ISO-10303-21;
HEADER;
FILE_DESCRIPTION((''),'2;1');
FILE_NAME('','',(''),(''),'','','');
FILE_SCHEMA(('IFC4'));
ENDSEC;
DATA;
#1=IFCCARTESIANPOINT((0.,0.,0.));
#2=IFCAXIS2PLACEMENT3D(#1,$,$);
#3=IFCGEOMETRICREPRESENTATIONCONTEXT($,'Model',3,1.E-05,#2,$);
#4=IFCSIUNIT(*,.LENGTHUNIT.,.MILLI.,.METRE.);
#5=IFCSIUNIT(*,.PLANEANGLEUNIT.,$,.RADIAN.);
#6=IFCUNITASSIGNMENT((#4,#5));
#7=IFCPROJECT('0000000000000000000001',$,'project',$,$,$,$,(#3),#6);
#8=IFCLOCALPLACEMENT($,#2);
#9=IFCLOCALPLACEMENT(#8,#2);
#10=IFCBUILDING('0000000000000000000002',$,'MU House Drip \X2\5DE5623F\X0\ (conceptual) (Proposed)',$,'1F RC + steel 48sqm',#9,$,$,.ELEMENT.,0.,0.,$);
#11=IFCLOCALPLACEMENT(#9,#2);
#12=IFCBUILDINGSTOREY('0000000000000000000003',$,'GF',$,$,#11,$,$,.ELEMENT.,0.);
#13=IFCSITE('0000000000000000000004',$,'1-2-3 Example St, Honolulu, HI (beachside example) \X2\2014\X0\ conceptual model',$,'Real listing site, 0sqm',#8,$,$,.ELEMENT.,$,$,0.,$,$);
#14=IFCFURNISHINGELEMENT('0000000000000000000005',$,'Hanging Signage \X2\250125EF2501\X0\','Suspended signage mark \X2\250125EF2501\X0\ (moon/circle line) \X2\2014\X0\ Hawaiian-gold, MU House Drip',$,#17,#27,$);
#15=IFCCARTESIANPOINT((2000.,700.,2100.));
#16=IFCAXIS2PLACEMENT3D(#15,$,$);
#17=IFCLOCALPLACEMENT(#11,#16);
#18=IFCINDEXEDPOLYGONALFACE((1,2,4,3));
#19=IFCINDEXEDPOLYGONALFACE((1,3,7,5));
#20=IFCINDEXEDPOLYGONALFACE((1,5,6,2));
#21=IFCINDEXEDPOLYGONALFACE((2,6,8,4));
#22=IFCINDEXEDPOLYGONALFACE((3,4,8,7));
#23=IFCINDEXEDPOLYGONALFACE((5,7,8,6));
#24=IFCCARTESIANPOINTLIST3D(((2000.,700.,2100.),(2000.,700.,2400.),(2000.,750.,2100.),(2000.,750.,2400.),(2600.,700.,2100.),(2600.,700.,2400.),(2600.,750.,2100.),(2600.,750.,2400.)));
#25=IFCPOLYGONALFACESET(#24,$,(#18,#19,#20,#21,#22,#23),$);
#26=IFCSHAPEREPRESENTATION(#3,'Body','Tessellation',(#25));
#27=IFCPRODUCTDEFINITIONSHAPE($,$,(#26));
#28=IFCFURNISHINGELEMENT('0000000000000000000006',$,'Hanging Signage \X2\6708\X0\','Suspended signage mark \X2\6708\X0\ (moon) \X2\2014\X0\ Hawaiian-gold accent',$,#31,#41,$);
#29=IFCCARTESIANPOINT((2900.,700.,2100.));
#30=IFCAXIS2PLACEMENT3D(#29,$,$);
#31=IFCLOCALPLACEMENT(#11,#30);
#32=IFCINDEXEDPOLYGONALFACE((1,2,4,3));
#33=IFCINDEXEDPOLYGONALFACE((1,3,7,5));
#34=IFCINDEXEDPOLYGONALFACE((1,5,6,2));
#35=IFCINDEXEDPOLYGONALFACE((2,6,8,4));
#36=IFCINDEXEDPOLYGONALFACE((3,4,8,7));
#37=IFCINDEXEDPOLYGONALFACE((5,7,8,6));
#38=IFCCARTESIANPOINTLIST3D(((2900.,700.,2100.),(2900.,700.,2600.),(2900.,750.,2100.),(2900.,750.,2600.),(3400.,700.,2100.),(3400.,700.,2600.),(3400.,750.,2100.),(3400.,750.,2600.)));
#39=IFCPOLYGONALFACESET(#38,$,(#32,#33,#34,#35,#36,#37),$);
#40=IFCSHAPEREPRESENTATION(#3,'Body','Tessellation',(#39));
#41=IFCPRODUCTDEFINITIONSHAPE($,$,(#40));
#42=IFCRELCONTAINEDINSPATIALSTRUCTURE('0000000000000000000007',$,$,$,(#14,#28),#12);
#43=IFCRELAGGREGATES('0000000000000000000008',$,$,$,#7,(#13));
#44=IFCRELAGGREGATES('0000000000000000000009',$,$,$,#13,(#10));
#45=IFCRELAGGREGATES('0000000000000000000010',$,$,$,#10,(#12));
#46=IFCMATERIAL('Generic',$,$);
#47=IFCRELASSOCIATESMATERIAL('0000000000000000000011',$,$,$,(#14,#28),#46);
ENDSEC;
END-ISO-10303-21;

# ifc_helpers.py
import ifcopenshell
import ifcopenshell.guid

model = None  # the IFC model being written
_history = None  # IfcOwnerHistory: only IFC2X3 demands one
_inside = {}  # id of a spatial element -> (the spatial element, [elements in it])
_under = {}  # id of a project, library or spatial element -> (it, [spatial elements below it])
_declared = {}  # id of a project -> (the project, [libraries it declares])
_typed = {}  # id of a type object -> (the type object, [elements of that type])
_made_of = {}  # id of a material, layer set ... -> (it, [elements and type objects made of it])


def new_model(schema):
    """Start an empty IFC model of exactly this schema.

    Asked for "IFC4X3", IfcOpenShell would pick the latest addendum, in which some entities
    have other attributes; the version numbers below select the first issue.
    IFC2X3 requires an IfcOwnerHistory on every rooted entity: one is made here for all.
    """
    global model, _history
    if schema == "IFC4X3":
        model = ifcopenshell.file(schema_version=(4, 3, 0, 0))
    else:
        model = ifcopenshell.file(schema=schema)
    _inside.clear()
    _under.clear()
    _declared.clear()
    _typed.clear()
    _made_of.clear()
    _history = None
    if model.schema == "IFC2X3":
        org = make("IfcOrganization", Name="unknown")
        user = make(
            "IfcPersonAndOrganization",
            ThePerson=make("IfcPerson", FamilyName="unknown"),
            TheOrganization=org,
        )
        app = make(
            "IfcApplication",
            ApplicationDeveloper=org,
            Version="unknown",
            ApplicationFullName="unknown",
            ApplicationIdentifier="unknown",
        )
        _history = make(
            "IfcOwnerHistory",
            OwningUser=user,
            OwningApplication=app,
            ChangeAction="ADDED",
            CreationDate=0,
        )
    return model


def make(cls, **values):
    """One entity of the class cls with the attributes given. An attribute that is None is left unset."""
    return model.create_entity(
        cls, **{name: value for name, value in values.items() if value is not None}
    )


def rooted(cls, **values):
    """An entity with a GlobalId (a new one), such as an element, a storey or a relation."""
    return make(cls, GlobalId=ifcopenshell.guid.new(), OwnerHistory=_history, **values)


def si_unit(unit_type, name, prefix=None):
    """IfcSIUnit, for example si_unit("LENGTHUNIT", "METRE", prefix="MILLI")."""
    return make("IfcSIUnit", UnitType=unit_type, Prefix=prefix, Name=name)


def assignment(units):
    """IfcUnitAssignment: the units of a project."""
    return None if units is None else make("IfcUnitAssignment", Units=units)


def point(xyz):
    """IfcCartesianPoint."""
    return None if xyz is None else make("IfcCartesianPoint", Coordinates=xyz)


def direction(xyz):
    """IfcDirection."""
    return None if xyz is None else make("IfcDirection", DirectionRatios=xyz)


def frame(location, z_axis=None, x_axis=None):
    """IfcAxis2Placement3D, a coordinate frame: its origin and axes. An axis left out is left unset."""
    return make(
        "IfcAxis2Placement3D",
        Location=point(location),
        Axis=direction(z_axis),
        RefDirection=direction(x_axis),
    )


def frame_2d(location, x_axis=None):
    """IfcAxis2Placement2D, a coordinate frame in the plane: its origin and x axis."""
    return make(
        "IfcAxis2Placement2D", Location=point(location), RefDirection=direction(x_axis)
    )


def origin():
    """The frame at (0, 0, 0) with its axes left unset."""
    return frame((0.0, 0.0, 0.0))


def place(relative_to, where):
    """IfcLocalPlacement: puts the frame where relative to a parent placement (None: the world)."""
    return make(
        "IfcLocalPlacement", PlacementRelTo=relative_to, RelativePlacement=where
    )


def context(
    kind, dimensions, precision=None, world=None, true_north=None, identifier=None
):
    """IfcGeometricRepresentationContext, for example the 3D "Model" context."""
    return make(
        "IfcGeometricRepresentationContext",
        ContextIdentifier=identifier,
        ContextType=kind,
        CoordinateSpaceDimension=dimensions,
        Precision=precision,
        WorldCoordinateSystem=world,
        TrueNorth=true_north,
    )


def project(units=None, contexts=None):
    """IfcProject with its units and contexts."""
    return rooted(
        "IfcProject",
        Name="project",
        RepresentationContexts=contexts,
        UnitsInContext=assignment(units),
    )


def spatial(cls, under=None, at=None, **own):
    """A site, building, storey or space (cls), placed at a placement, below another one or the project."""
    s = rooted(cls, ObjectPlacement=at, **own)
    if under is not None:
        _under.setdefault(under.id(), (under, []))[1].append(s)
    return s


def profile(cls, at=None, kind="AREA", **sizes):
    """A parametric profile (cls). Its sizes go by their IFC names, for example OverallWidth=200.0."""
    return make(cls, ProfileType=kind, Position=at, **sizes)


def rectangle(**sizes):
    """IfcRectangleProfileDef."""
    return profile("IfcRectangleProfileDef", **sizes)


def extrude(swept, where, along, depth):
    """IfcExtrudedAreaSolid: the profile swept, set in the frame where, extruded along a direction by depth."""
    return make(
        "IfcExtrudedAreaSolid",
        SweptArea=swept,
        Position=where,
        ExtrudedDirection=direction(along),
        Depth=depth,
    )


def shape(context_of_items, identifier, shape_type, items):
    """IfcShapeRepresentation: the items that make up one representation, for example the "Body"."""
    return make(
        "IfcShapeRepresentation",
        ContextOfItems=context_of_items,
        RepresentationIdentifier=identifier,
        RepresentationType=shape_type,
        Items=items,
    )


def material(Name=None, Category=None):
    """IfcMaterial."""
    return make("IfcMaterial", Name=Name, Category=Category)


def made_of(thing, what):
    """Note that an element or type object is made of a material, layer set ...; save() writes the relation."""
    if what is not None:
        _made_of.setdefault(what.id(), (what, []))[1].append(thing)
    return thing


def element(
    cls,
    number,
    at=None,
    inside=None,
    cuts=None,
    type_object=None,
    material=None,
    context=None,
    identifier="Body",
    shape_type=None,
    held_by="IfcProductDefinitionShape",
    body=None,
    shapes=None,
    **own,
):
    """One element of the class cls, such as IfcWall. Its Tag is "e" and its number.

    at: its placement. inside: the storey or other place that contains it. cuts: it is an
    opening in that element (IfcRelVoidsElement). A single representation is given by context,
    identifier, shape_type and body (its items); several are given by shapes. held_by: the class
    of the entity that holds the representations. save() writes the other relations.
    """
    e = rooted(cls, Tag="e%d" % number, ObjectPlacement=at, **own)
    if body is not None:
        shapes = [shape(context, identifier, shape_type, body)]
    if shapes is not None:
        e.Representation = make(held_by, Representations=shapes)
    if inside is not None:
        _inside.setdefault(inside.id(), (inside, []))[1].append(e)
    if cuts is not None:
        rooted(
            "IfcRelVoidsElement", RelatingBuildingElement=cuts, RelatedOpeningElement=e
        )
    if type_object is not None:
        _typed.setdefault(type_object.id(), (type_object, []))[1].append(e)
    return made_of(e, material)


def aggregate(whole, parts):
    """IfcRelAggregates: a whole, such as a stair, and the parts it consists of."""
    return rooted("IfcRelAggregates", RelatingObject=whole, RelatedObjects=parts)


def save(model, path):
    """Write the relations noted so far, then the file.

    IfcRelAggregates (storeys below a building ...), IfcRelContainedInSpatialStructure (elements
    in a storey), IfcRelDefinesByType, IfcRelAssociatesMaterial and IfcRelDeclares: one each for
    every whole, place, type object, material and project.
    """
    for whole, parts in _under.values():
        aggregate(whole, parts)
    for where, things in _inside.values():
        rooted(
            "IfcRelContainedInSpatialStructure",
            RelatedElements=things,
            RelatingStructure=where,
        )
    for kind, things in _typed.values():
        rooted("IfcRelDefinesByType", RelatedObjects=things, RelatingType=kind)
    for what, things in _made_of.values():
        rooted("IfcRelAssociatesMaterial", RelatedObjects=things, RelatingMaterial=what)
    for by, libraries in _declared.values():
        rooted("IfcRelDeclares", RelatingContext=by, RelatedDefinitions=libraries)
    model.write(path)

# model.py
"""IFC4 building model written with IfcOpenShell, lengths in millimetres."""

from ifc_helpers import new_model, si_unit, frame, frame_2d, origin, place, context, project, spatial, rectangle, extrude, material, element, save


model = new_model("IFC4")

# Units and contexts
model_context = context("Model", 3, precision=1e-05, world=origin())
ifc_project = project(units=[si_unit("LENGTHUNIT", "METRE", prefix="MILLI"), si_unit("PLANEANGLEUNIT", "RADIAN")], contexts=[model_context])

# Site, building, storey
site_placement = place(None, origin())
site = spatial("IfcSite", under=ifc_project, at=site_placement, Name="1-2-3 Example St, Honolulu, HI (beachside example) — conceptual model", ObjectType="Real listing site, 0sqm", CompositionType="ELEMENT", RefElevation=0.0)
building_placement = place(site_placement, origin())
building = spatial("IfcBuilding", under=site, at=building_placement, Name="MU House Drip 工房 (conceptual) (Proposed)", ObjectType="1F RC + steel 48sqm", CompositionType="ELEMENT", ElevationOfRefHeight=0.0, ElevationOfTerrain=0.0)
storey_placement = place(building_placement, origin())
storey = spatial("IfcBuildingStorey", under=building, at=storey_placement, Name="GF", CompositionType="ELEMENT", Elevation=0.0)

# Shared definitions
ifc_material_1 = material(Name="Generic")

# Furnishing elements
furnishing_1_placement = place(storey_placement, frame((2000.0, 700.0, 2100.0)))
element("IfcFurnishingElement", 1, at=furnishing_1_placement, inside=storey, material=ifc_material_1, Name="Hanging Signage ━◯━", Description="Suspended signage mark ━◯━ (moon/circle line) — Hawaiian-gold, MU House Drip", context=model_context, shape_type="SweptSolid", body=[
    extrude(rectangle(XDim=600.0, YDim=50.0, at=frame_2d((300.0, 25.0))), frame((2000.0, 700.0, 2100.0)), (0.0, 0.0, 1.0), 300.0),
])
furnishing_2_placement = place(storey_placement, frame((2900.0, 700.0, 2100.0)))
element("IfcFurnishingElement", 2, at=furnishing_2_placement, inside=storey, material=ifc_material_1, Name="Hanging Signage 月", Description="Suspended signage mark 月 (moon) — Hawaiian-gold accent", context=model_context, shape_type="SweptSolid", body=[
    extrude(rectangle(XDim=500.0, YDim=50.0, at=frame_2d((250.0, 25.0))), frame((2900.0, 700.0, 2100.0)), (0.0, 0.0, 1.0), 500.0),
])

save(model, "model.ifc")
